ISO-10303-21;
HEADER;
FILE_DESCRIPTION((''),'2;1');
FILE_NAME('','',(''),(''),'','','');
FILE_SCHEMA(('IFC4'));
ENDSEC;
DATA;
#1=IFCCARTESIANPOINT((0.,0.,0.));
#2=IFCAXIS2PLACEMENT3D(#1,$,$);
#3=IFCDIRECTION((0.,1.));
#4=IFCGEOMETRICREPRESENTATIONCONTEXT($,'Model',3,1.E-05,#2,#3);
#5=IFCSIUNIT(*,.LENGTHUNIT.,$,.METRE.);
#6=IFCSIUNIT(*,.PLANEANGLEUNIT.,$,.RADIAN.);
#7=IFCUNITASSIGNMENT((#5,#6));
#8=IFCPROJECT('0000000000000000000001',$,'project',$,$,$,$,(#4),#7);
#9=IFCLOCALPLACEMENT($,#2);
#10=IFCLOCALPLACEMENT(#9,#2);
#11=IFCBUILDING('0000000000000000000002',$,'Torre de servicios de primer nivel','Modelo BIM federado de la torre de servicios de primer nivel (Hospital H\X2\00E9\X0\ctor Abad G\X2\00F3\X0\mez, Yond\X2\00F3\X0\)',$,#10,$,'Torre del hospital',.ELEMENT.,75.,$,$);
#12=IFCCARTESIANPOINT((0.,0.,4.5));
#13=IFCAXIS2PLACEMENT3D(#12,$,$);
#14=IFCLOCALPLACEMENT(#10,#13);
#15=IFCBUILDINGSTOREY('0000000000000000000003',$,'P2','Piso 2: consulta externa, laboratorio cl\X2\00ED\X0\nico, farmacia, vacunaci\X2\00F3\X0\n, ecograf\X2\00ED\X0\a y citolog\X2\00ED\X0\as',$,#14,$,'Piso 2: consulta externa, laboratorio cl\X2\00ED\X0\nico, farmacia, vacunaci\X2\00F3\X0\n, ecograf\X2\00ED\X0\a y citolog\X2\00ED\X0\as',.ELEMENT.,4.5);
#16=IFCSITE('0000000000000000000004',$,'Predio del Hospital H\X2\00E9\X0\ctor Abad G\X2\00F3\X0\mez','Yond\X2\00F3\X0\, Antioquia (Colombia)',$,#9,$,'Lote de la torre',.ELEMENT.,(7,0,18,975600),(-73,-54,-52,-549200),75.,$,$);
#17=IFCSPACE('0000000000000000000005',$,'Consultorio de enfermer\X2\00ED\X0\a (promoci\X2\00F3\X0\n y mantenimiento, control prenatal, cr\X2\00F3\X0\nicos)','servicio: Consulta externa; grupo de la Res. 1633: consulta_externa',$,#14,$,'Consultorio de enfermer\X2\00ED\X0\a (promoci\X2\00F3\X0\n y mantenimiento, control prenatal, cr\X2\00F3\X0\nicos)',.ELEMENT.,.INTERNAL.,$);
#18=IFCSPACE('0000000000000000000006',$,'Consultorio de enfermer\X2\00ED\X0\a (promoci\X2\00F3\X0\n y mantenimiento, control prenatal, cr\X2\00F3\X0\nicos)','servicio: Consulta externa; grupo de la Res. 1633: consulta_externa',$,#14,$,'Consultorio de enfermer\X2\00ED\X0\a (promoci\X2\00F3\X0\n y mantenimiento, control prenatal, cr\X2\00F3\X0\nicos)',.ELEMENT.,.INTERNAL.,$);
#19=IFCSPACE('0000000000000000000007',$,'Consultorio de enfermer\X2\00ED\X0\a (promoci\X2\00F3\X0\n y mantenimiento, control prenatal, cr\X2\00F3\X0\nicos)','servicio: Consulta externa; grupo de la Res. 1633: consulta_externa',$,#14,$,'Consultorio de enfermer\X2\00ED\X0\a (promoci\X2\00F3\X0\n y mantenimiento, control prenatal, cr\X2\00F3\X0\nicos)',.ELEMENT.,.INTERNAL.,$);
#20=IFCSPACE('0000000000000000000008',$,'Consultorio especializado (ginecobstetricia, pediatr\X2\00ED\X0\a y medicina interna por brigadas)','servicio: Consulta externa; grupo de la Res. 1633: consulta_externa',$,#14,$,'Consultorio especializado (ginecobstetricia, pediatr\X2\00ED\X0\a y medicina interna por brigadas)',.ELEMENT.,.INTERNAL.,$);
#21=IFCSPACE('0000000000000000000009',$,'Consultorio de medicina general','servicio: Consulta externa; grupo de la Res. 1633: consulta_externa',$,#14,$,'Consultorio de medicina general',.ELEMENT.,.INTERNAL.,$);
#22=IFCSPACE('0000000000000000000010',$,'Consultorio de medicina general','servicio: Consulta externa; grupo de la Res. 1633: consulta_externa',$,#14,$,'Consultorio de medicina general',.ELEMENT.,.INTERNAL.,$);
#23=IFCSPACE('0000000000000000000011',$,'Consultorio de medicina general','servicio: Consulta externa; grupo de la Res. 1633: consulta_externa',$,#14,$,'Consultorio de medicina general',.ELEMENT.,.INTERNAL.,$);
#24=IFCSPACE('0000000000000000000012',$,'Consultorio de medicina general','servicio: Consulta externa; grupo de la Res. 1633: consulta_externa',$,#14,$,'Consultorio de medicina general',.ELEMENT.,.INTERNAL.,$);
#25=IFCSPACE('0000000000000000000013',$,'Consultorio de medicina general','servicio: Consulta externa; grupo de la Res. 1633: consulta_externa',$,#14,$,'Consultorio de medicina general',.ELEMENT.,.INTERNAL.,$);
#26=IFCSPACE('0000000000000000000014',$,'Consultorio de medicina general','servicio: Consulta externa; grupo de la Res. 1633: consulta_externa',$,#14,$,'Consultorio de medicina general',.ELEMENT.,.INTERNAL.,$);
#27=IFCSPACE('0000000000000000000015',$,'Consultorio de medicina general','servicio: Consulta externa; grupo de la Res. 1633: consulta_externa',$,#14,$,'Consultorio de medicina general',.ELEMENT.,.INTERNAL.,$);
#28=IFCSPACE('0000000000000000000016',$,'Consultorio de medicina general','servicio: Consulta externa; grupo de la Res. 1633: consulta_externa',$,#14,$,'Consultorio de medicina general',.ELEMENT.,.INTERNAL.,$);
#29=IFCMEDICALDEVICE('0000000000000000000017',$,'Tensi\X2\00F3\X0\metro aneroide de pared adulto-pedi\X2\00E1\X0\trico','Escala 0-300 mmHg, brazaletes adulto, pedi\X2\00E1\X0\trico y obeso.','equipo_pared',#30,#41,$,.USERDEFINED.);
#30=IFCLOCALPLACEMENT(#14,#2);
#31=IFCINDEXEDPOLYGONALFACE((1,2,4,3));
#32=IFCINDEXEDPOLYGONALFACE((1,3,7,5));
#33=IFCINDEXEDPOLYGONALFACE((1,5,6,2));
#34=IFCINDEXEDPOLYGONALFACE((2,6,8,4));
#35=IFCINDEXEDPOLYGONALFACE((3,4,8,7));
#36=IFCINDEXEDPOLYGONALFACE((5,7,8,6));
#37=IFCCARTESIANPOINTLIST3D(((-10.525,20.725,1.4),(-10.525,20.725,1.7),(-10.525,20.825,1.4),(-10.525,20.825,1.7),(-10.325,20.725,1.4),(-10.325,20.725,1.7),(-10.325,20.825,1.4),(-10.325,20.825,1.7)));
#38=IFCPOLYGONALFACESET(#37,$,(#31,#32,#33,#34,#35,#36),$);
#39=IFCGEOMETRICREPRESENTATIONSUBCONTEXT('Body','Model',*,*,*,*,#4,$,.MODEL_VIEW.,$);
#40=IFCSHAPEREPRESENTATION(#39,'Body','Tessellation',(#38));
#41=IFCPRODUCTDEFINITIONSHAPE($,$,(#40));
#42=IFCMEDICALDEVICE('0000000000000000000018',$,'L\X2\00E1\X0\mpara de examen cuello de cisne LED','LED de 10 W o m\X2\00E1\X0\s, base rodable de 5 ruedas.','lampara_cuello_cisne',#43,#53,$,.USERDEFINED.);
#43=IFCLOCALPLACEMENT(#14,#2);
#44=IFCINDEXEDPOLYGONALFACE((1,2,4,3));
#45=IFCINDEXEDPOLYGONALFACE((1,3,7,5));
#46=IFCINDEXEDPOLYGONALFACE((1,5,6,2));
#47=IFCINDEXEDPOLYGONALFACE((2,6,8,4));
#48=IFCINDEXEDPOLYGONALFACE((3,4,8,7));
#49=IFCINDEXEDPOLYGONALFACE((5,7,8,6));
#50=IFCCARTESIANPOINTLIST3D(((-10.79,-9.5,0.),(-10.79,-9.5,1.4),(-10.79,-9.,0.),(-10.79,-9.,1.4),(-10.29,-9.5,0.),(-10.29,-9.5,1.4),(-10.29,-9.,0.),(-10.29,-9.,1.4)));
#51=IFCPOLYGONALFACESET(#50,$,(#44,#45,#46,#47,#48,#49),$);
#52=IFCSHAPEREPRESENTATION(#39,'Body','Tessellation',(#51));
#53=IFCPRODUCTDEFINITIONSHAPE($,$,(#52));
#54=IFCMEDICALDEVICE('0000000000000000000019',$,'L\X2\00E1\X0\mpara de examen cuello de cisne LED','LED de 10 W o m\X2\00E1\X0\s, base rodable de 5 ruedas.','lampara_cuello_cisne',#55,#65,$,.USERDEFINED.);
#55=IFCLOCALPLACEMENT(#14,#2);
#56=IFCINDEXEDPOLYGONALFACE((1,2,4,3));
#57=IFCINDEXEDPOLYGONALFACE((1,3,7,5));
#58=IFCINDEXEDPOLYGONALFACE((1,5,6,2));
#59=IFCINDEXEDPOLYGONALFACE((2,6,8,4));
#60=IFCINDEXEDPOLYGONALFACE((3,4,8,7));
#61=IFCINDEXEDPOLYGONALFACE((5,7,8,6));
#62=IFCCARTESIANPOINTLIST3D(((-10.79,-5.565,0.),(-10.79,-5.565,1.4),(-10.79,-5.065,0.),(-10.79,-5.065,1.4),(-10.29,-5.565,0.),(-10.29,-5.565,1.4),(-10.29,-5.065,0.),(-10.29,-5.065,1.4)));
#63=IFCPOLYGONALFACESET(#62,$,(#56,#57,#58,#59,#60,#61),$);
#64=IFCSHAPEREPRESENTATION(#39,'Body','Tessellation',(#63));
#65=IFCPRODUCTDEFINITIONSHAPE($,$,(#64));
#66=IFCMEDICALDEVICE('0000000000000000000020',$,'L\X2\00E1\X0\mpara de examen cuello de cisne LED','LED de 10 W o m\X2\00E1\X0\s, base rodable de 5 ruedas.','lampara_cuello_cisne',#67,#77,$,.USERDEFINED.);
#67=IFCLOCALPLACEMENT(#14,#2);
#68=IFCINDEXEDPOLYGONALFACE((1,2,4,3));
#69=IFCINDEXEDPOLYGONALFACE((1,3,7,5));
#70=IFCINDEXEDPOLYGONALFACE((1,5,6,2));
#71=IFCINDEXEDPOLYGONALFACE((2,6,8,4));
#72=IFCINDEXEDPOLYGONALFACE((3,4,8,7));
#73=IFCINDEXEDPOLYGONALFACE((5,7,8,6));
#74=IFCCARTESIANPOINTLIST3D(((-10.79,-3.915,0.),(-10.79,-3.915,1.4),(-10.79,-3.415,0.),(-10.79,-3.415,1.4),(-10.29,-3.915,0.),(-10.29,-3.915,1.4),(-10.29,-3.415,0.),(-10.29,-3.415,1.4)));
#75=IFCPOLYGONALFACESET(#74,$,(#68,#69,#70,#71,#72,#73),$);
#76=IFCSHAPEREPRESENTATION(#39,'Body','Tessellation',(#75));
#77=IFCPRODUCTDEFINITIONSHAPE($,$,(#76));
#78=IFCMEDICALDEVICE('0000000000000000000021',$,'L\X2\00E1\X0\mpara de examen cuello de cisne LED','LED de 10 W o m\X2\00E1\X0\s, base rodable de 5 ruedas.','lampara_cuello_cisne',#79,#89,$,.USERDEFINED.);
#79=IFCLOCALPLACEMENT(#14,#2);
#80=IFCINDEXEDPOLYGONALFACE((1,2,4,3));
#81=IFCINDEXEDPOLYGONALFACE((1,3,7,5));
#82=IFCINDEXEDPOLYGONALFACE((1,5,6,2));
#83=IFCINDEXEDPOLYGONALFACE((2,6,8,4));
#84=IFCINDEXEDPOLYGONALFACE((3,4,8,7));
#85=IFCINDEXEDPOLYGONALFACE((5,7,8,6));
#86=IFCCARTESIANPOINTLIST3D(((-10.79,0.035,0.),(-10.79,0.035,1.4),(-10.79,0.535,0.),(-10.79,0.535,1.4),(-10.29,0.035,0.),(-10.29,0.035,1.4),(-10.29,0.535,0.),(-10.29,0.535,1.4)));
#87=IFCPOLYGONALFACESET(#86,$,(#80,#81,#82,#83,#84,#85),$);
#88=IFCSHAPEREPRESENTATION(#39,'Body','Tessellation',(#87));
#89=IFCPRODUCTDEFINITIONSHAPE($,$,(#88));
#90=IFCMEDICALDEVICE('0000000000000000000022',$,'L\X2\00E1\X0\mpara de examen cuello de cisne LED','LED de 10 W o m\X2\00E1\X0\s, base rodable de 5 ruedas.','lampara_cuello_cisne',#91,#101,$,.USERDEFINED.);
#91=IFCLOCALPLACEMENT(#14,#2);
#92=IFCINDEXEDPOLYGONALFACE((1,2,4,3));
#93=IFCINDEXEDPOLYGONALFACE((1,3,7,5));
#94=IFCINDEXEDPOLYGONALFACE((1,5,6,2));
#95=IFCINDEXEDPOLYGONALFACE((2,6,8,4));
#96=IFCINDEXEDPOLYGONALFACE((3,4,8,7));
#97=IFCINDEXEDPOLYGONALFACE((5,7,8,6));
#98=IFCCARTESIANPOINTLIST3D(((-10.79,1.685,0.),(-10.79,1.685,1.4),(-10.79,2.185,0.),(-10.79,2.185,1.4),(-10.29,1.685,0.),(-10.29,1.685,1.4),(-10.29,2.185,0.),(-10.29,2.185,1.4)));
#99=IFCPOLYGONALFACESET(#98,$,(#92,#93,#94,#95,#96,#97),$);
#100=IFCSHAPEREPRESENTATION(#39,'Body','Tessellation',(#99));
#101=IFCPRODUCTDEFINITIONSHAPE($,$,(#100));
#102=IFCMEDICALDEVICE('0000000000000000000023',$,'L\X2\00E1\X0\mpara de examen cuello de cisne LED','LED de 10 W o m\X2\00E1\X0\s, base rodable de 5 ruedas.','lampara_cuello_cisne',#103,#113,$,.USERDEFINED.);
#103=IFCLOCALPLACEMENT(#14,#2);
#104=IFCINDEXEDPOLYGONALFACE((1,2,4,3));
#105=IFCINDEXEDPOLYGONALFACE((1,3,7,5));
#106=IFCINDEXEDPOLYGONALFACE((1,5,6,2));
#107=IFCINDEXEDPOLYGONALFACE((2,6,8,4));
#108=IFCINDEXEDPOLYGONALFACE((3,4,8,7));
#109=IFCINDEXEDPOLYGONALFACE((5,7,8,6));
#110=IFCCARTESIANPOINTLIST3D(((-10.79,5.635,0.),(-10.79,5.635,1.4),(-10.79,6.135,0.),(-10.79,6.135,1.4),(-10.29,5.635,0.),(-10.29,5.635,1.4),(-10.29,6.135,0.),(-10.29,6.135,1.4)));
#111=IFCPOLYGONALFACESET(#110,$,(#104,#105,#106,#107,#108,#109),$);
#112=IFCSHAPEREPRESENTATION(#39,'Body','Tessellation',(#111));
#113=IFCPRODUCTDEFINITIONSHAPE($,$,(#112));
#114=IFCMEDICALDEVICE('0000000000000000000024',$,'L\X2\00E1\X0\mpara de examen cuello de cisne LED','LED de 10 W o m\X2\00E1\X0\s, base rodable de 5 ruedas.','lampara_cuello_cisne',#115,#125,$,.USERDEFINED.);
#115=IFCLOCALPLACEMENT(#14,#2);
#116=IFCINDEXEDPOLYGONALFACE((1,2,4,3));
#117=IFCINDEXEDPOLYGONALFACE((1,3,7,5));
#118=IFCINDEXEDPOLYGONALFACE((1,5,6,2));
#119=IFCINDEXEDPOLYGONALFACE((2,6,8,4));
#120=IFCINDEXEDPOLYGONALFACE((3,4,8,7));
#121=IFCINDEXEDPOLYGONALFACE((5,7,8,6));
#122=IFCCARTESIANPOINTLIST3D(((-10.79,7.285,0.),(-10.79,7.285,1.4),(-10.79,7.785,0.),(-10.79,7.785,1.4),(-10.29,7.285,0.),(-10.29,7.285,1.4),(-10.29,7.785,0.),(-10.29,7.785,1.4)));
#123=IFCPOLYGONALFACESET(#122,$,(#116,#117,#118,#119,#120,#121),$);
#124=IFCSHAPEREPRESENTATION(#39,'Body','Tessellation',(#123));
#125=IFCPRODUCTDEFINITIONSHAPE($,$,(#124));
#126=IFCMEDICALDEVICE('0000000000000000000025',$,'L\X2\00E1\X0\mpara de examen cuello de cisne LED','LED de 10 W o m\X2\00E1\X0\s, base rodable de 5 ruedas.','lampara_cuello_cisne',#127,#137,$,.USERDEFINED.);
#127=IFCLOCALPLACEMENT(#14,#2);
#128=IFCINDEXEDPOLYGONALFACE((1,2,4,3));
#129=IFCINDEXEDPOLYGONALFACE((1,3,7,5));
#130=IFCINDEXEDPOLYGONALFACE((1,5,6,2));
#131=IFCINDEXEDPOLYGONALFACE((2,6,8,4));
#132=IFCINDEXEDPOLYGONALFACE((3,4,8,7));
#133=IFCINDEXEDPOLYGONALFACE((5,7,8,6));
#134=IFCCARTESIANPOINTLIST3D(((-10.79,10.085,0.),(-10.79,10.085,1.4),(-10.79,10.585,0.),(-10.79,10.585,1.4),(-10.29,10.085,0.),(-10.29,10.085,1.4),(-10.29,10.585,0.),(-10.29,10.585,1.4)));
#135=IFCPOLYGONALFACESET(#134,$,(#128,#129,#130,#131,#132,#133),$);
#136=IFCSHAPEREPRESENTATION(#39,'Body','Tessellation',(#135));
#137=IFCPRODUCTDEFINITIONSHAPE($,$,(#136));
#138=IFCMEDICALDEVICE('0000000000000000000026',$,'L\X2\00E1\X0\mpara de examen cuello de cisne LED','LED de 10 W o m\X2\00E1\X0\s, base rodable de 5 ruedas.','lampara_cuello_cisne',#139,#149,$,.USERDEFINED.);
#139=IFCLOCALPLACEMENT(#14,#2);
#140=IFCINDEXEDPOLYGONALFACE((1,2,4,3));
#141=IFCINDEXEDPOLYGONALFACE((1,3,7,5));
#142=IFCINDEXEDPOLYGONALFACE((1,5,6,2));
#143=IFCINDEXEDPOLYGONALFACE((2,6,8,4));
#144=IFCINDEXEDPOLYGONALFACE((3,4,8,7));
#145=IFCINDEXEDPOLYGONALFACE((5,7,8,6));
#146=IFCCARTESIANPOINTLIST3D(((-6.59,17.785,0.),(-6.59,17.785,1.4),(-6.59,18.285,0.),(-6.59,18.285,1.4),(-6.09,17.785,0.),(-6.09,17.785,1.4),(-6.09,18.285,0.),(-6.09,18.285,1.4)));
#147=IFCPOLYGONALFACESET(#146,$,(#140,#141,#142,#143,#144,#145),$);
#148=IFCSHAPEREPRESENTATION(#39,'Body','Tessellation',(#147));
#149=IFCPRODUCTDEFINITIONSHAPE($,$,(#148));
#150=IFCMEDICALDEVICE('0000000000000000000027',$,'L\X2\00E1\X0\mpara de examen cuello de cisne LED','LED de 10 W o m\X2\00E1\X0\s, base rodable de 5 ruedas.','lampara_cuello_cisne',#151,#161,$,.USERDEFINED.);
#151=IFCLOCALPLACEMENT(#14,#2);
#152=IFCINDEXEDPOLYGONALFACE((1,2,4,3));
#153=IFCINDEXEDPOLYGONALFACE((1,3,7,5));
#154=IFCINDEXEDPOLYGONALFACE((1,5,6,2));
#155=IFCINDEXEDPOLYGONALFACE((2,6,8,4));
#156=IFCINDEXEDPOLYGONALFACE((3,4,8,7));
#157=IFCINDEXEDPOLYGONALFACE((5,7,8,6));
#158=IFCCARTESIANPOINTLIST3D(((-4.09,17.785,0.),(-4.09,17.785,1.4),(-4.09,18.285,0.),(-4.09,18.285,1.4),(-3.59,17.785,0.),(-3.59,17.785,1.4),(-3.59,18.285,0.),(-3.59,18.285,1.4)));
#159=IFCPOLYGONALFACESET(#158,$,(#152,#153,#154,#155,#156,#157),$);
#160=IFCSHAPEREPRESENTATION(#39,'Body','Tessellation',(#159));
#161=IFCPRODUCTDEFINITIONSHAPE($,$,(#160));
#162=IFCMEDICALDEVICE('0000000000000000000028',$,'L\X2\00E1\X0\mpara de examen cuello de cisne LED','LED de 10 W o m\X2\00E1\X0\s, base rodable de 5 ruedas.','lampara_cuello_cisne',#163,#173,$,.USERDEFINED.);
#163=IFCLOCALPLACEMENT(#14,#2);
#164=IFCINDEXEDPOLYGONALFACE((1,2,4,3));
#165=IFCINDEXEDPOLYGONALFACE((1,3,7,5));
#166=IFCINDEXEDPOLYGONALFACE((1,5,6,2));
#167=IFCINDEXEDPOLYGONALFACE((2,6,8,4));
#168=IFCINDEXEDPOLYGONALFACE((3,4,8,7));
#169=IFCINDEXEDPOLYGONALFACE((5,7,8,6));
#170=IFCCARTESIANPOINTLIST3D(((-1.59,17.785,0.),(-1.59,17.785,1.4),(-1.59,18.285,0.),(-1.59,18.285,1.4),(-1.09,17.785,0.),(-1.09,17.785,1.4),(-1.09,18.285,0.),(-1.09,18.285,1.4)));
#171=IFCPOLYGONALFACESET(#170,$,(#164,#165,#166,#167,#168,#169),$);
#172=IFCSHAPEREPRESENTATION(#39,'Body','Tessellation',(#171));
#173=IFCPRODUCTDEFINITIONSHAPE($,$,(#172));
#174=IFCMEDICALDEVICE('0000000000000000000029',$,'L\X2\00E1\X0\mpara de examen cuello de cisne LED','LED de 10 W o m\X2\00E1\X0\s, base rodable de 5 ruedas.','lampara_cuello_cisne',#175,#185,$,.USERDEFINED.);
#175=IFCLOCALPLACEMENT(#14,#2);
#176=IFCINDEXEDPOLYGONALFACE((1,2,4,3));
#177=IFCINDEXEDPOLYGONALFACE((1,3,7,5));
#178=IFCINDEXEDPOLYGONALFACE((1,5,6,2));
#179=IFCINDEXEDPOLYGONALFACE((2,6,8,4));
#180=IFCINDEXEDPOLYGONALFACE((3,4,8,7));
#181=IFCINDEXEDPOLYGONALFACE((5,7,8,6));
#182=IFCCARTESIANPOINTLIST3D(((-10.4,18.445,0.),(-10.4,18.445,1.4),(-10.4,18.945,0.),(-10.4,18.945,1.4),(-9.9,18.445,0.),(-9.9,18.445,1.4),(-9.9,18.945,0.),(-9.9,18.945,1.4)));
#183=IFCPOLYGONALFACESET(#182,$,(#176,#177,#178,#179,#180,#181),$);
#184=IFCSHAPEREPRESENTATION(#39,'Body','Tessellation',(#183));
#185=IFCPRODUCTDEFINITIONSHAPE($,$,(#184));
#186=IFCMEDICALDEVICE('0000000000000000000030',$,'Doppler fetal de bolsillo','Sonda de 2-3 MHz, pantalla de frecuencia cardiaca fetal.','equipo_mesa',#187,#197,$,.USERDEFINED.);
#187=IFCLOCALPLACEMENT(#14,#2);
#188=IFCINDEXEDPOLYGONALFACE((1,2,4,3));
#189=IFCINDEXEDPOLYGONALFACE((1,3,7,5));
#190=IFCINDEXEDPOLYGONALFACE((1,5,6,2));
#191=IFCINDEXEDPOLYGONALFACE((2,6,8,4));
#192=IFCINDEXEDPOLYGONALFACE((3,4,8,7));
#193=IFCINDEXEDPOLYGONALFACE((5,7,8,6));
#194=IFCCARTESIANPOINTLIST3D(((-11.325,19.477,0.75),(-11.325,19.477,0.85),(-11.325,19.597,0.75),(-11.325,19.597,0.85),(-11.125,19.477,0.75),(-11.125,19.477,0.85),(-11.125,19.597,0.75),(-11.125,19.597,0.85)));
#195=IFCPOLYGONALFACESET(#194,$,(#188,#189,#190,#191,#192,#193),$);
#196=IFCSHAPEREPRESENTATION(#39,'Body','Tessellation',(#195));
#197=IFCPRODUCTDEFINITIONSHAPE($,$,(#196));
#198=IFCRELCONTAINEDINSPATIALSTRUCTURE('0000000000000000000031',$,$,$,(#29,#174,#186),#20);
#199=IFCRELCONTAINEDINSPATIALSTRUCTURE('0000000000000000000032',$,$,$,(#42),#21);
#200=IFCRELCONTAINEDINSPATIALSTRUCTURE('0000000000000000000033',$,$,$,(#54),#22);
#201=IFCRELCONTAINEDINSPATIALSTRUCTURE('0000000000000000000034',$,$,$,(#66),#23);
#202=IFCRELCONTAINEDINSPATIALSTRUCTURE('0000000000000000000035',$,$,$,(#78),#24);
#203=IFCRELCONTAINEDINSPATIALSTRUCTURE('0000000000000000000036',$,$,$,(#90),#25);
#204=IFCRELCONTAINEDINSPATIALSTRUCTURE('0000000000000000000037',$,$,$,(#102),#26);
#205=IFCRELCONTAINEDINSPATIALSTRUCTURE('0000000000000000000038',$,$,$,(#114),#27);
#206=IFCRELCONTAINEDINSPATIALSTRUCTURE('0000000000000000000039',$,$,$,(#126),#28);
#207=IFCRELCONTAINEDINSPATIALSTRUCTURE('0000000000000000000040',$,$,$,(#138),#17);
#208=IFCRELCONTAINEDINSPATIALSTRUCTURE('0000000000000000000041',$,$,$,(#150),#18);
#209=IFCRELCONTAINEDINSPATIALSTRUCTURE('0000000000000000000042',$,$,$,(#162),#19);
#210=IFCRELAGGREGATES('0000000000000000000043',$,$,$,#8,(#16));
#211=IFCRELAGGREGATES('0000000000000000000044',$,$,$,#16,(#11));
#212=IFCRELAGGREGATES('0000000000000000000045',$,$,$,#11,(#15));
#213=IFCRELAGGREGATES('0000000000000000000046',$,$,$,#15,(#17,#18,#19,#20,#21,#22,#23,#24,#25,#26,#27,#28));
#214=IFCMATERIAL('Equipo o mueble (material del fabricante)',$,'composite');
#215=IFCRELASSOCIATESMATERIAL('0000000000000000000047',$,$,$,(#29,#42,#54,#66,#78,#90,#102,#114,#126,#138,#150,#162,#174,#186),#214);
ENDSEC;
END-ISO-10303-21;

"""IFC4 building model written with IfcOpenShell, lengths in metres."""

from ifc_helpers import new_model, si_unit, direction, frame, origin, place, context, subcontext, project, spatial, rectangle, extrude, material, element, save


model = new_model("IFC4")

# Units and contexts
model_context = context("Model", 3, precision=1e-05, world=origin(), true_north=direction((0.0, 1.0)))
body_context = subcontext(model_context, "Body", "Model", "MODEL_VIEW")
ifc_project = project(units=[si_unit("LENGTHUNIT", "METRE"), si_unit("PLANEANGLEUNIT", "RADIAN")], contexts=[model_context])

# Site, building, storey, space
site_placement = place(None, origin())
site = spatial("IfcSite", under=ifc_project, at=site_placement, Name="Predio del Hospital Héctor Abad Gómez", Description="Yondó, Antioquia (Colombia)", LongName="Lote de la torre", CompositionType="ELEMENT", RefLatitude=(7, 0, 18, 975600), RefLongitude=(-73, -54, -52, -549200), RefElevation=75.0)
building_placement = place(site_placement, origin())
building = spatial("IfcBuilding", under=site, at=building_placement, Name="Torre de servicios de primer nivel", Description="Modelo BIM federado de la torre de servicios de primer nivel (Hospital Héctor Abad Gómez, Yondó)", LongName="Torre del hospital", CompositionType="ELEMENT", ElevationOfRefHeight=75.0)
placement = place(building_placement, frame((0.0, 0.0, 4.5)))
storey = spatial("IfcBuildingStorey", under=building, at=placement, Name="P2", Description="Piso 2: consulta externa, laboratorio clínico, farmacia, vacunación, ecografía y citologías", LongName="Piso 2: consulta externa, laboratorio clínico, farmacia, vacunación, ecografía y citologías", CompositionType="ELEMENT", Elevation=4.5)
space_1 = spatial("IfcSpace", under=storey, at=placement, Name="Consultorio de enfermería (promoción y mantenimiento, control prenatal, crónicos)", Description="servicio: Consulta externa; grupo de la Res. 1633: consulta_externa", LongName="Consultorio de enfermería (promoción y mantenimiento, control prenatal, crónicos)", CompositionType="ELEMENT", PredefinedType="INTERNAL")

# Shared definitions
ifc_material = material(Name="Equipo o mueble (material del fabricante)", Category="composite")

# Shared definitions
space_2 = spatial("IfcSpace", under=storey, at=placement, Name="Consultorio de enfermería (promoción y mantenimiento, control prenatal, crónicos)", Description="servicio: Consulta externa; grupo de la Res. 1633: consulta_externa", LongName="Consultorio de enfermería (promoción y mantenimiento, control prenatal, crónicos)", CompositionType="ELEMENT", PredefinedType="INTERNAL")

# Shared definitions
space_3 = spatial("IfcSpace", under=storey, at=placement, Name="Consultorio de enfermería (promoción y mantenimiento, control prenatal, crónicos)", Description="servicio: Consulta externa; grupo de la Res. 1633: consulta_externa", LongName="Consultorio de enfermería (promoción y mantenimiento, control prenatal, crónicos)", CompositionType="ELEMENT", PredefinedType="INTERNAL")

# Shared definitions
space_4 = spatial("IfcSpace", under=storey, at=placement, Name="Consultorio especializado (ginecobstetricia, pediatría y medicina interna por brigadas)", Description="servicio: Consulta externa; grupo de la Res. 1633: consulta_externa", LongName="Consultorio especializado (ginecobstetricia, pediatría y medicina interna por brigadas)", CompositionType="ELEMENT", PredefinedType="INTERNAL")

# Shared definitions
space_5 = spatial("IfcSpace", under=storey, at=placement, Name="Consultorio de medicina general", Description="servicio: Consulta externa; grupo de la Res. 1633: consulta_externa", LongName="Consultorio de medicina general", CompositionType="ELEMENT", PredefinedType="INTERNAL")

# Shared definitions
space_6 = spatial("IfcSpace", under=storey, at=placement, Name="Consultorio de medicina general", Description="servicio: Consulta externa; grupo de la Res. 1633: consulta_externa", LongName="Consultorio de medicina general", CompositionType="ELEMENT", PredefinedType="INTERNAL")

# Shared definitions
space_7 = spatial("IfcSpace", under=storey, at=placement, Name="Consultorio de medicina general", Description="servicio: Consulta externa; grupo de la Res. 1633: consulta_externa", LongName="Consultorio de medicina general", CompositionType="ELEMENT", PredefinedType="INTERNAL")

# Shared definitions
space_8 = spatial("IfcSpace", under=storey, at=placement, Name="Consultorio de medicina general", Description="servicio: Consulta externa; grupo de la Res. 1633: consulta_externa", LongName="Consultorio de medicina general", CompositionType="ELEMENT", PredefinedType="INTERNAL")

# Shared definitions
space_9 = spatial("IfcSpace", under=storey, at=placement, Name="Consultorio de medicina general", Description="servicio: Consulta externa; grupo de la Res. 1633: consulta_externa", LongName="Consultorio de medicina general", CompositionType="ELEMENT", PredefinedType="INTERNAL")

# Shared definitions
space_10 = spatial("IfcSpace", under=storey, at=placement, Name="Consultorio de medicina general", Description="servicio: Consulta externa; grupo de la Res. 1633: consulta_externa", LongName="Consultorio de medicina general", CompositionType="ELEMENT", PredefinedType="INTERNAL")

# Shared definitions
space_11 = spatial("IfcSpace", under=storey, at=placement, Name="Consultorio de medicina general", Description="servicio: Consulta externa; grupo de la Res. 1633: consulta_externa", LongName="Consultorio de medicina general", CompositionType="ELEMENT", PredefinedType="INTERNAL")

# Shared definitions
space_12 = spatial("IfcSpace", under=storey, at=placement, Name="Consultorio de medicina general", Description="servicio: Consulta externa; grupo de la Res. 1633: consulta_externa", LongName="Consultorio de medicina general", CompositionType="ELEMENT", PredefinedType="INTERNAL")

# Medical devices
element("IfcMedicalDevice", 1, at=placement, inside=space_4, material=ifc_material, Name="Tensiómetro aneroide de pared adulto-pediátrico", Description="Escala 0-300 mmHg, brazaletes adulto, pediátrico y obeso.", ObjectType="equipo_pared", PredefinedType="USERDEFINED", context=body_context, shape_type="SweptSolid", body=[
    extrude(rectangle(XDim=0.2, YDim=0.1), frame((-10.425, 20.775, 1.4), z_axis=(0.0, 0.0, 1.0), x_axis=(-1.0, 0.0, 0.0)), (0.0, 0.0, 1.0), 0.3),
])
element("IfcMedicalDevice", 2, at=placement, inside=space_5, material=ifc_material, Name="Lámpara de examen cuello de cisne LED", Description="LED de 10 W o más, base rodable de 5 ruedas.", ObjectType="lampara_cuello_cisne", PredefinedType="USERDEFINED", context=body_context, shape_type="SweptSolid", body=[
    extrude(rectangle(XDim=0.5, YDim=0.5), frame((-10.54, -9.25, 0.0), z_axis=(0.0, 0.0, 1.0), x_axis=(0.0, 1.0, 0.0)), (0.0, 0.0, 1.0), 1.4),
])
element("IfcMedicalDevice", 3, at=placement, inside=space_6, material=ifc_material, Name="Lámpara de examen cuello de cisne LED", Description="LED de 10 W o más, base rodable de 5 ruedas.", ObjectType="lampara_cuello_cisne", PredefinedType="USERDEFINED", context=body_context, shape_type="SweptSolid", body=[
    extrude(rectangle(XDim=0.5, YDim=0.5), frame((-10.54, -5.315, 0.0), z_axis=(0.0, 0.0, 1.0), x_axis=(0.0, 1.0, 0.0)), (0.0, 0.0, 1.0), 1.4),
])
element("IfcMedicalDevice", 4, at=placement, inside=space_7, material=ifc_material, Name="Lámpara de examen cuello de cisne LED", Description="LED de 10 W o más, base rodable de 5 ruedas.", ObjectType="lampara_cuello_cisne", PredefinedType="USERDEFINED", context=body_context, shape_type="SweptSolid", body=[
    extrude(rectangle(XDim=0.5, YDim=0.5), frame((-10.54, -3.665, 0.0), z_axis=(0.0, 0.0, 1.0), x_axis=(0.0, 1.0, 0.0)), (0.0, 0.0, 1.0), 1.4),
])
element("IfcMedicalDevice", 5, at=placement, inside=space_8, material=ifc_material, Name="Lámpara de examen cuello de cisne LED", Description="LED de 10 W o más, base rodable de 5 ruedas.", ObjectType="lampara_cuello_cisne", PredefinedType="USERDEFINED", context=body_context, shape_type="SweptSolid", body=[
    extrude(rectangle(XDim=0.5, YDim=0.5), frame((-10.54, 0.285, 0.0), z_axis=(0.0, 0.0, 1.0), x_axis=(0.0, 1.0, 0.0)), (0.0, 0.0, 1.0), 1.4),
])
element("IfcMedicalDevice", 6, at=placement, inside=space_9, material=ifc_material, Name="Lámpara de examen cuello de cisne LED", Description="LED de 10 W o más, base rodable de 5 ruedas.", ObjectType="lampara_cuello_cisne", PredefinedType="USERDEFINED", context=body_context, shape_type="SweptSolid", body=[
    extrude(rectangle(XDim=0.5, YDim=0.5), frame((-10.54, 1.935, 0.0), z_axis=(0.0, 0.0, 1.0), x_axis=(0.0, 1.0, 0.0)), (0.0, 0.0, 1.0), 1.4),
])
element("IfcMedicalDevice", 7, at=placement, inside=space_10, material=ifc_material, Name="Lámpara de examen cuello de cisne LED", Description="LED de 10 W o más, base rodable de 5 ruedas.", ObjectType="lampara_cuello_cisne", PredefinedType="USERDEFINED", context=body_context, shape_type="SweptSolid", body=[
    extrude(rectangle(XDim=0.5, YDim=0.5), frame((-10.54, 5.885, 0.0), z_axis=(0.0, 0.0, 1.0), x_axis=(0.0, 1.0, 0.0)), (0.0, 0.0, 1.0), 1.4),
])
element("IfcMedicalDevice", 8, at=placement, inside=space_11, material=ifc_material, Name="Lámpara de examen cuello de cisne LED", Description="LED de 10 W o más, base rodable de 5 ruedas.", ObjectType="lampara_cuello_cisne", PredefinedType="USERDEFINED", context=body_context, shape_type="SweptSolid", body=[
    extrude(rectangle(XDim=0.5, YDim=0.5), frame((-10.54, 7.535, 0.0), z_axis=(0.0, 0.0, 1.0), x_axis=(0.0, 1.0, 0.0)), (0.0, 0.0, 1.0), 1.4),
])
element("IfcMedicalDevice", 9, at=placement, inside=space_12, material=ifc_material, Name="Lámpara de examen cuello de cisne LED", Description="LED de 10 W o más, base rodable de 5 ruedas.", ObjectType="lampara_cuello_cisne", PredefinedType="USERDEFINED", context=body_context, shape_type="SweptSolid", body=[
    extrude(rectangle(XDim=0.5, YDim=0.5), frame((-10.54, 10.335, 0.0), z_axis=(0.0, 0.0, 1.0), x_axis=(0.0, 1.0, 0.0)), (0.0, 0.0, 1.0), 1.4),
])
element("IfcMedicalDevice", 10, at=placement, inside=space_1, material=ifc_material, Name="Lámpara de examen cuello de cisne LED", Description="LED de 10 W o más, base rodable de 5 ruedas.", ObjectType="lampara_cuello_cisne", PredefinedType="USERDEFINED", context=body_context, shape_type="SweptSolid", body=[
    extrude(rectangle(XDim=0.5, YDim=0.5), frame((-6.34, 18.035, 0.0), z_axis=(0.0, 0.0, 1.0), x_axis=(0.0, 1.0, 0.0)), (0.0, 0.0, 1.0), 1.4),
])
element("IfcMedicalDevice", 11, at=placement, inside=space_2, material=ifc_material, Name="Lámpara de examen cuello de cisne LED", Description="LED de 10 W o más, base rodable de 5 ruedas.", ObjectType="lampara_cuello_cisne", PredefinedType="USERDEFINED", context=body_context, shape_type="SweptSolid", body=[
    extrude(rectangle(XDim=0.5, YDim=0.5), frame((-3.84, 18.035, 0.0), z_axis=(0.0, 0.0, 1.0), x_axis=(0.0, 1.0, 0.0)), (0.0, 0.0, 1.0), 1.4),
])
element("IfcMedicalDevice", 12, at=placement, inside=space_3, material=ifc_material, Name="Lámpara de examen cuello de cisne LED", Description="LED de 10 W o más, base rodable de 5 ruedas.", ObjectType="lampara_cuello_cisne", PredefinedType="USERDEFINED", context=body_context, shape_type="SweptSolid", body=[
    extrude(rectangle(XDim=0.5, YDim=0.5), frame((-1.34, 18.035, 0.0), z_axis=(0.0, 0.0, 1.0), x_axis=(0.0, 1.0, 0.0)), (0.0, 0.0, 1.0), 1.4),
])
element("IfcMedicalDevice", 13, at=placement, inside=space_4, material=ifc_material, Name="Lámpara de examen cuello de cisne LED", Description="LED de 10 W o más, base rodable de 5 ruedas.", ObjectType="lampara_cuello_cisne", PredefinedType="USERDEFINED", context=body_context, shape_type="SweptSolid", body=[
    extrude(rectangle(XDim=0.5, YDim=0.5), frame((-10.15, 18.695, 0.0), z_axis=(0.0, 0.0, 1.0), x_axis=(-1.0, 0.0, 0.0)), (0.0, 0.0, 1.0), 1.4),
])
element("IfcMedicalDevice", 14, at=placement, inside=space_4, material=ifc_material, Name="Doppler fetal de bolsillo", Description="Sonda de 2-3 MHz, pantalla de frecuencia cardiaca fetal.", ObjectType="equipo_mesa", PredefinedType="USERDEFINED", context=body_context, shape_type="SweptSolid", body=[
    extrude(rectangle(XDim=0.2, YDim=0.12), frame((-11.225, 19.537, 0.75), z_axis=(0.0, 0.0, 1.0), x_axis=(-1.0, 0.0, 0.0)), (0.0, 0.0, 1.0), 0.1),
])

save(model, "model.ifc")
